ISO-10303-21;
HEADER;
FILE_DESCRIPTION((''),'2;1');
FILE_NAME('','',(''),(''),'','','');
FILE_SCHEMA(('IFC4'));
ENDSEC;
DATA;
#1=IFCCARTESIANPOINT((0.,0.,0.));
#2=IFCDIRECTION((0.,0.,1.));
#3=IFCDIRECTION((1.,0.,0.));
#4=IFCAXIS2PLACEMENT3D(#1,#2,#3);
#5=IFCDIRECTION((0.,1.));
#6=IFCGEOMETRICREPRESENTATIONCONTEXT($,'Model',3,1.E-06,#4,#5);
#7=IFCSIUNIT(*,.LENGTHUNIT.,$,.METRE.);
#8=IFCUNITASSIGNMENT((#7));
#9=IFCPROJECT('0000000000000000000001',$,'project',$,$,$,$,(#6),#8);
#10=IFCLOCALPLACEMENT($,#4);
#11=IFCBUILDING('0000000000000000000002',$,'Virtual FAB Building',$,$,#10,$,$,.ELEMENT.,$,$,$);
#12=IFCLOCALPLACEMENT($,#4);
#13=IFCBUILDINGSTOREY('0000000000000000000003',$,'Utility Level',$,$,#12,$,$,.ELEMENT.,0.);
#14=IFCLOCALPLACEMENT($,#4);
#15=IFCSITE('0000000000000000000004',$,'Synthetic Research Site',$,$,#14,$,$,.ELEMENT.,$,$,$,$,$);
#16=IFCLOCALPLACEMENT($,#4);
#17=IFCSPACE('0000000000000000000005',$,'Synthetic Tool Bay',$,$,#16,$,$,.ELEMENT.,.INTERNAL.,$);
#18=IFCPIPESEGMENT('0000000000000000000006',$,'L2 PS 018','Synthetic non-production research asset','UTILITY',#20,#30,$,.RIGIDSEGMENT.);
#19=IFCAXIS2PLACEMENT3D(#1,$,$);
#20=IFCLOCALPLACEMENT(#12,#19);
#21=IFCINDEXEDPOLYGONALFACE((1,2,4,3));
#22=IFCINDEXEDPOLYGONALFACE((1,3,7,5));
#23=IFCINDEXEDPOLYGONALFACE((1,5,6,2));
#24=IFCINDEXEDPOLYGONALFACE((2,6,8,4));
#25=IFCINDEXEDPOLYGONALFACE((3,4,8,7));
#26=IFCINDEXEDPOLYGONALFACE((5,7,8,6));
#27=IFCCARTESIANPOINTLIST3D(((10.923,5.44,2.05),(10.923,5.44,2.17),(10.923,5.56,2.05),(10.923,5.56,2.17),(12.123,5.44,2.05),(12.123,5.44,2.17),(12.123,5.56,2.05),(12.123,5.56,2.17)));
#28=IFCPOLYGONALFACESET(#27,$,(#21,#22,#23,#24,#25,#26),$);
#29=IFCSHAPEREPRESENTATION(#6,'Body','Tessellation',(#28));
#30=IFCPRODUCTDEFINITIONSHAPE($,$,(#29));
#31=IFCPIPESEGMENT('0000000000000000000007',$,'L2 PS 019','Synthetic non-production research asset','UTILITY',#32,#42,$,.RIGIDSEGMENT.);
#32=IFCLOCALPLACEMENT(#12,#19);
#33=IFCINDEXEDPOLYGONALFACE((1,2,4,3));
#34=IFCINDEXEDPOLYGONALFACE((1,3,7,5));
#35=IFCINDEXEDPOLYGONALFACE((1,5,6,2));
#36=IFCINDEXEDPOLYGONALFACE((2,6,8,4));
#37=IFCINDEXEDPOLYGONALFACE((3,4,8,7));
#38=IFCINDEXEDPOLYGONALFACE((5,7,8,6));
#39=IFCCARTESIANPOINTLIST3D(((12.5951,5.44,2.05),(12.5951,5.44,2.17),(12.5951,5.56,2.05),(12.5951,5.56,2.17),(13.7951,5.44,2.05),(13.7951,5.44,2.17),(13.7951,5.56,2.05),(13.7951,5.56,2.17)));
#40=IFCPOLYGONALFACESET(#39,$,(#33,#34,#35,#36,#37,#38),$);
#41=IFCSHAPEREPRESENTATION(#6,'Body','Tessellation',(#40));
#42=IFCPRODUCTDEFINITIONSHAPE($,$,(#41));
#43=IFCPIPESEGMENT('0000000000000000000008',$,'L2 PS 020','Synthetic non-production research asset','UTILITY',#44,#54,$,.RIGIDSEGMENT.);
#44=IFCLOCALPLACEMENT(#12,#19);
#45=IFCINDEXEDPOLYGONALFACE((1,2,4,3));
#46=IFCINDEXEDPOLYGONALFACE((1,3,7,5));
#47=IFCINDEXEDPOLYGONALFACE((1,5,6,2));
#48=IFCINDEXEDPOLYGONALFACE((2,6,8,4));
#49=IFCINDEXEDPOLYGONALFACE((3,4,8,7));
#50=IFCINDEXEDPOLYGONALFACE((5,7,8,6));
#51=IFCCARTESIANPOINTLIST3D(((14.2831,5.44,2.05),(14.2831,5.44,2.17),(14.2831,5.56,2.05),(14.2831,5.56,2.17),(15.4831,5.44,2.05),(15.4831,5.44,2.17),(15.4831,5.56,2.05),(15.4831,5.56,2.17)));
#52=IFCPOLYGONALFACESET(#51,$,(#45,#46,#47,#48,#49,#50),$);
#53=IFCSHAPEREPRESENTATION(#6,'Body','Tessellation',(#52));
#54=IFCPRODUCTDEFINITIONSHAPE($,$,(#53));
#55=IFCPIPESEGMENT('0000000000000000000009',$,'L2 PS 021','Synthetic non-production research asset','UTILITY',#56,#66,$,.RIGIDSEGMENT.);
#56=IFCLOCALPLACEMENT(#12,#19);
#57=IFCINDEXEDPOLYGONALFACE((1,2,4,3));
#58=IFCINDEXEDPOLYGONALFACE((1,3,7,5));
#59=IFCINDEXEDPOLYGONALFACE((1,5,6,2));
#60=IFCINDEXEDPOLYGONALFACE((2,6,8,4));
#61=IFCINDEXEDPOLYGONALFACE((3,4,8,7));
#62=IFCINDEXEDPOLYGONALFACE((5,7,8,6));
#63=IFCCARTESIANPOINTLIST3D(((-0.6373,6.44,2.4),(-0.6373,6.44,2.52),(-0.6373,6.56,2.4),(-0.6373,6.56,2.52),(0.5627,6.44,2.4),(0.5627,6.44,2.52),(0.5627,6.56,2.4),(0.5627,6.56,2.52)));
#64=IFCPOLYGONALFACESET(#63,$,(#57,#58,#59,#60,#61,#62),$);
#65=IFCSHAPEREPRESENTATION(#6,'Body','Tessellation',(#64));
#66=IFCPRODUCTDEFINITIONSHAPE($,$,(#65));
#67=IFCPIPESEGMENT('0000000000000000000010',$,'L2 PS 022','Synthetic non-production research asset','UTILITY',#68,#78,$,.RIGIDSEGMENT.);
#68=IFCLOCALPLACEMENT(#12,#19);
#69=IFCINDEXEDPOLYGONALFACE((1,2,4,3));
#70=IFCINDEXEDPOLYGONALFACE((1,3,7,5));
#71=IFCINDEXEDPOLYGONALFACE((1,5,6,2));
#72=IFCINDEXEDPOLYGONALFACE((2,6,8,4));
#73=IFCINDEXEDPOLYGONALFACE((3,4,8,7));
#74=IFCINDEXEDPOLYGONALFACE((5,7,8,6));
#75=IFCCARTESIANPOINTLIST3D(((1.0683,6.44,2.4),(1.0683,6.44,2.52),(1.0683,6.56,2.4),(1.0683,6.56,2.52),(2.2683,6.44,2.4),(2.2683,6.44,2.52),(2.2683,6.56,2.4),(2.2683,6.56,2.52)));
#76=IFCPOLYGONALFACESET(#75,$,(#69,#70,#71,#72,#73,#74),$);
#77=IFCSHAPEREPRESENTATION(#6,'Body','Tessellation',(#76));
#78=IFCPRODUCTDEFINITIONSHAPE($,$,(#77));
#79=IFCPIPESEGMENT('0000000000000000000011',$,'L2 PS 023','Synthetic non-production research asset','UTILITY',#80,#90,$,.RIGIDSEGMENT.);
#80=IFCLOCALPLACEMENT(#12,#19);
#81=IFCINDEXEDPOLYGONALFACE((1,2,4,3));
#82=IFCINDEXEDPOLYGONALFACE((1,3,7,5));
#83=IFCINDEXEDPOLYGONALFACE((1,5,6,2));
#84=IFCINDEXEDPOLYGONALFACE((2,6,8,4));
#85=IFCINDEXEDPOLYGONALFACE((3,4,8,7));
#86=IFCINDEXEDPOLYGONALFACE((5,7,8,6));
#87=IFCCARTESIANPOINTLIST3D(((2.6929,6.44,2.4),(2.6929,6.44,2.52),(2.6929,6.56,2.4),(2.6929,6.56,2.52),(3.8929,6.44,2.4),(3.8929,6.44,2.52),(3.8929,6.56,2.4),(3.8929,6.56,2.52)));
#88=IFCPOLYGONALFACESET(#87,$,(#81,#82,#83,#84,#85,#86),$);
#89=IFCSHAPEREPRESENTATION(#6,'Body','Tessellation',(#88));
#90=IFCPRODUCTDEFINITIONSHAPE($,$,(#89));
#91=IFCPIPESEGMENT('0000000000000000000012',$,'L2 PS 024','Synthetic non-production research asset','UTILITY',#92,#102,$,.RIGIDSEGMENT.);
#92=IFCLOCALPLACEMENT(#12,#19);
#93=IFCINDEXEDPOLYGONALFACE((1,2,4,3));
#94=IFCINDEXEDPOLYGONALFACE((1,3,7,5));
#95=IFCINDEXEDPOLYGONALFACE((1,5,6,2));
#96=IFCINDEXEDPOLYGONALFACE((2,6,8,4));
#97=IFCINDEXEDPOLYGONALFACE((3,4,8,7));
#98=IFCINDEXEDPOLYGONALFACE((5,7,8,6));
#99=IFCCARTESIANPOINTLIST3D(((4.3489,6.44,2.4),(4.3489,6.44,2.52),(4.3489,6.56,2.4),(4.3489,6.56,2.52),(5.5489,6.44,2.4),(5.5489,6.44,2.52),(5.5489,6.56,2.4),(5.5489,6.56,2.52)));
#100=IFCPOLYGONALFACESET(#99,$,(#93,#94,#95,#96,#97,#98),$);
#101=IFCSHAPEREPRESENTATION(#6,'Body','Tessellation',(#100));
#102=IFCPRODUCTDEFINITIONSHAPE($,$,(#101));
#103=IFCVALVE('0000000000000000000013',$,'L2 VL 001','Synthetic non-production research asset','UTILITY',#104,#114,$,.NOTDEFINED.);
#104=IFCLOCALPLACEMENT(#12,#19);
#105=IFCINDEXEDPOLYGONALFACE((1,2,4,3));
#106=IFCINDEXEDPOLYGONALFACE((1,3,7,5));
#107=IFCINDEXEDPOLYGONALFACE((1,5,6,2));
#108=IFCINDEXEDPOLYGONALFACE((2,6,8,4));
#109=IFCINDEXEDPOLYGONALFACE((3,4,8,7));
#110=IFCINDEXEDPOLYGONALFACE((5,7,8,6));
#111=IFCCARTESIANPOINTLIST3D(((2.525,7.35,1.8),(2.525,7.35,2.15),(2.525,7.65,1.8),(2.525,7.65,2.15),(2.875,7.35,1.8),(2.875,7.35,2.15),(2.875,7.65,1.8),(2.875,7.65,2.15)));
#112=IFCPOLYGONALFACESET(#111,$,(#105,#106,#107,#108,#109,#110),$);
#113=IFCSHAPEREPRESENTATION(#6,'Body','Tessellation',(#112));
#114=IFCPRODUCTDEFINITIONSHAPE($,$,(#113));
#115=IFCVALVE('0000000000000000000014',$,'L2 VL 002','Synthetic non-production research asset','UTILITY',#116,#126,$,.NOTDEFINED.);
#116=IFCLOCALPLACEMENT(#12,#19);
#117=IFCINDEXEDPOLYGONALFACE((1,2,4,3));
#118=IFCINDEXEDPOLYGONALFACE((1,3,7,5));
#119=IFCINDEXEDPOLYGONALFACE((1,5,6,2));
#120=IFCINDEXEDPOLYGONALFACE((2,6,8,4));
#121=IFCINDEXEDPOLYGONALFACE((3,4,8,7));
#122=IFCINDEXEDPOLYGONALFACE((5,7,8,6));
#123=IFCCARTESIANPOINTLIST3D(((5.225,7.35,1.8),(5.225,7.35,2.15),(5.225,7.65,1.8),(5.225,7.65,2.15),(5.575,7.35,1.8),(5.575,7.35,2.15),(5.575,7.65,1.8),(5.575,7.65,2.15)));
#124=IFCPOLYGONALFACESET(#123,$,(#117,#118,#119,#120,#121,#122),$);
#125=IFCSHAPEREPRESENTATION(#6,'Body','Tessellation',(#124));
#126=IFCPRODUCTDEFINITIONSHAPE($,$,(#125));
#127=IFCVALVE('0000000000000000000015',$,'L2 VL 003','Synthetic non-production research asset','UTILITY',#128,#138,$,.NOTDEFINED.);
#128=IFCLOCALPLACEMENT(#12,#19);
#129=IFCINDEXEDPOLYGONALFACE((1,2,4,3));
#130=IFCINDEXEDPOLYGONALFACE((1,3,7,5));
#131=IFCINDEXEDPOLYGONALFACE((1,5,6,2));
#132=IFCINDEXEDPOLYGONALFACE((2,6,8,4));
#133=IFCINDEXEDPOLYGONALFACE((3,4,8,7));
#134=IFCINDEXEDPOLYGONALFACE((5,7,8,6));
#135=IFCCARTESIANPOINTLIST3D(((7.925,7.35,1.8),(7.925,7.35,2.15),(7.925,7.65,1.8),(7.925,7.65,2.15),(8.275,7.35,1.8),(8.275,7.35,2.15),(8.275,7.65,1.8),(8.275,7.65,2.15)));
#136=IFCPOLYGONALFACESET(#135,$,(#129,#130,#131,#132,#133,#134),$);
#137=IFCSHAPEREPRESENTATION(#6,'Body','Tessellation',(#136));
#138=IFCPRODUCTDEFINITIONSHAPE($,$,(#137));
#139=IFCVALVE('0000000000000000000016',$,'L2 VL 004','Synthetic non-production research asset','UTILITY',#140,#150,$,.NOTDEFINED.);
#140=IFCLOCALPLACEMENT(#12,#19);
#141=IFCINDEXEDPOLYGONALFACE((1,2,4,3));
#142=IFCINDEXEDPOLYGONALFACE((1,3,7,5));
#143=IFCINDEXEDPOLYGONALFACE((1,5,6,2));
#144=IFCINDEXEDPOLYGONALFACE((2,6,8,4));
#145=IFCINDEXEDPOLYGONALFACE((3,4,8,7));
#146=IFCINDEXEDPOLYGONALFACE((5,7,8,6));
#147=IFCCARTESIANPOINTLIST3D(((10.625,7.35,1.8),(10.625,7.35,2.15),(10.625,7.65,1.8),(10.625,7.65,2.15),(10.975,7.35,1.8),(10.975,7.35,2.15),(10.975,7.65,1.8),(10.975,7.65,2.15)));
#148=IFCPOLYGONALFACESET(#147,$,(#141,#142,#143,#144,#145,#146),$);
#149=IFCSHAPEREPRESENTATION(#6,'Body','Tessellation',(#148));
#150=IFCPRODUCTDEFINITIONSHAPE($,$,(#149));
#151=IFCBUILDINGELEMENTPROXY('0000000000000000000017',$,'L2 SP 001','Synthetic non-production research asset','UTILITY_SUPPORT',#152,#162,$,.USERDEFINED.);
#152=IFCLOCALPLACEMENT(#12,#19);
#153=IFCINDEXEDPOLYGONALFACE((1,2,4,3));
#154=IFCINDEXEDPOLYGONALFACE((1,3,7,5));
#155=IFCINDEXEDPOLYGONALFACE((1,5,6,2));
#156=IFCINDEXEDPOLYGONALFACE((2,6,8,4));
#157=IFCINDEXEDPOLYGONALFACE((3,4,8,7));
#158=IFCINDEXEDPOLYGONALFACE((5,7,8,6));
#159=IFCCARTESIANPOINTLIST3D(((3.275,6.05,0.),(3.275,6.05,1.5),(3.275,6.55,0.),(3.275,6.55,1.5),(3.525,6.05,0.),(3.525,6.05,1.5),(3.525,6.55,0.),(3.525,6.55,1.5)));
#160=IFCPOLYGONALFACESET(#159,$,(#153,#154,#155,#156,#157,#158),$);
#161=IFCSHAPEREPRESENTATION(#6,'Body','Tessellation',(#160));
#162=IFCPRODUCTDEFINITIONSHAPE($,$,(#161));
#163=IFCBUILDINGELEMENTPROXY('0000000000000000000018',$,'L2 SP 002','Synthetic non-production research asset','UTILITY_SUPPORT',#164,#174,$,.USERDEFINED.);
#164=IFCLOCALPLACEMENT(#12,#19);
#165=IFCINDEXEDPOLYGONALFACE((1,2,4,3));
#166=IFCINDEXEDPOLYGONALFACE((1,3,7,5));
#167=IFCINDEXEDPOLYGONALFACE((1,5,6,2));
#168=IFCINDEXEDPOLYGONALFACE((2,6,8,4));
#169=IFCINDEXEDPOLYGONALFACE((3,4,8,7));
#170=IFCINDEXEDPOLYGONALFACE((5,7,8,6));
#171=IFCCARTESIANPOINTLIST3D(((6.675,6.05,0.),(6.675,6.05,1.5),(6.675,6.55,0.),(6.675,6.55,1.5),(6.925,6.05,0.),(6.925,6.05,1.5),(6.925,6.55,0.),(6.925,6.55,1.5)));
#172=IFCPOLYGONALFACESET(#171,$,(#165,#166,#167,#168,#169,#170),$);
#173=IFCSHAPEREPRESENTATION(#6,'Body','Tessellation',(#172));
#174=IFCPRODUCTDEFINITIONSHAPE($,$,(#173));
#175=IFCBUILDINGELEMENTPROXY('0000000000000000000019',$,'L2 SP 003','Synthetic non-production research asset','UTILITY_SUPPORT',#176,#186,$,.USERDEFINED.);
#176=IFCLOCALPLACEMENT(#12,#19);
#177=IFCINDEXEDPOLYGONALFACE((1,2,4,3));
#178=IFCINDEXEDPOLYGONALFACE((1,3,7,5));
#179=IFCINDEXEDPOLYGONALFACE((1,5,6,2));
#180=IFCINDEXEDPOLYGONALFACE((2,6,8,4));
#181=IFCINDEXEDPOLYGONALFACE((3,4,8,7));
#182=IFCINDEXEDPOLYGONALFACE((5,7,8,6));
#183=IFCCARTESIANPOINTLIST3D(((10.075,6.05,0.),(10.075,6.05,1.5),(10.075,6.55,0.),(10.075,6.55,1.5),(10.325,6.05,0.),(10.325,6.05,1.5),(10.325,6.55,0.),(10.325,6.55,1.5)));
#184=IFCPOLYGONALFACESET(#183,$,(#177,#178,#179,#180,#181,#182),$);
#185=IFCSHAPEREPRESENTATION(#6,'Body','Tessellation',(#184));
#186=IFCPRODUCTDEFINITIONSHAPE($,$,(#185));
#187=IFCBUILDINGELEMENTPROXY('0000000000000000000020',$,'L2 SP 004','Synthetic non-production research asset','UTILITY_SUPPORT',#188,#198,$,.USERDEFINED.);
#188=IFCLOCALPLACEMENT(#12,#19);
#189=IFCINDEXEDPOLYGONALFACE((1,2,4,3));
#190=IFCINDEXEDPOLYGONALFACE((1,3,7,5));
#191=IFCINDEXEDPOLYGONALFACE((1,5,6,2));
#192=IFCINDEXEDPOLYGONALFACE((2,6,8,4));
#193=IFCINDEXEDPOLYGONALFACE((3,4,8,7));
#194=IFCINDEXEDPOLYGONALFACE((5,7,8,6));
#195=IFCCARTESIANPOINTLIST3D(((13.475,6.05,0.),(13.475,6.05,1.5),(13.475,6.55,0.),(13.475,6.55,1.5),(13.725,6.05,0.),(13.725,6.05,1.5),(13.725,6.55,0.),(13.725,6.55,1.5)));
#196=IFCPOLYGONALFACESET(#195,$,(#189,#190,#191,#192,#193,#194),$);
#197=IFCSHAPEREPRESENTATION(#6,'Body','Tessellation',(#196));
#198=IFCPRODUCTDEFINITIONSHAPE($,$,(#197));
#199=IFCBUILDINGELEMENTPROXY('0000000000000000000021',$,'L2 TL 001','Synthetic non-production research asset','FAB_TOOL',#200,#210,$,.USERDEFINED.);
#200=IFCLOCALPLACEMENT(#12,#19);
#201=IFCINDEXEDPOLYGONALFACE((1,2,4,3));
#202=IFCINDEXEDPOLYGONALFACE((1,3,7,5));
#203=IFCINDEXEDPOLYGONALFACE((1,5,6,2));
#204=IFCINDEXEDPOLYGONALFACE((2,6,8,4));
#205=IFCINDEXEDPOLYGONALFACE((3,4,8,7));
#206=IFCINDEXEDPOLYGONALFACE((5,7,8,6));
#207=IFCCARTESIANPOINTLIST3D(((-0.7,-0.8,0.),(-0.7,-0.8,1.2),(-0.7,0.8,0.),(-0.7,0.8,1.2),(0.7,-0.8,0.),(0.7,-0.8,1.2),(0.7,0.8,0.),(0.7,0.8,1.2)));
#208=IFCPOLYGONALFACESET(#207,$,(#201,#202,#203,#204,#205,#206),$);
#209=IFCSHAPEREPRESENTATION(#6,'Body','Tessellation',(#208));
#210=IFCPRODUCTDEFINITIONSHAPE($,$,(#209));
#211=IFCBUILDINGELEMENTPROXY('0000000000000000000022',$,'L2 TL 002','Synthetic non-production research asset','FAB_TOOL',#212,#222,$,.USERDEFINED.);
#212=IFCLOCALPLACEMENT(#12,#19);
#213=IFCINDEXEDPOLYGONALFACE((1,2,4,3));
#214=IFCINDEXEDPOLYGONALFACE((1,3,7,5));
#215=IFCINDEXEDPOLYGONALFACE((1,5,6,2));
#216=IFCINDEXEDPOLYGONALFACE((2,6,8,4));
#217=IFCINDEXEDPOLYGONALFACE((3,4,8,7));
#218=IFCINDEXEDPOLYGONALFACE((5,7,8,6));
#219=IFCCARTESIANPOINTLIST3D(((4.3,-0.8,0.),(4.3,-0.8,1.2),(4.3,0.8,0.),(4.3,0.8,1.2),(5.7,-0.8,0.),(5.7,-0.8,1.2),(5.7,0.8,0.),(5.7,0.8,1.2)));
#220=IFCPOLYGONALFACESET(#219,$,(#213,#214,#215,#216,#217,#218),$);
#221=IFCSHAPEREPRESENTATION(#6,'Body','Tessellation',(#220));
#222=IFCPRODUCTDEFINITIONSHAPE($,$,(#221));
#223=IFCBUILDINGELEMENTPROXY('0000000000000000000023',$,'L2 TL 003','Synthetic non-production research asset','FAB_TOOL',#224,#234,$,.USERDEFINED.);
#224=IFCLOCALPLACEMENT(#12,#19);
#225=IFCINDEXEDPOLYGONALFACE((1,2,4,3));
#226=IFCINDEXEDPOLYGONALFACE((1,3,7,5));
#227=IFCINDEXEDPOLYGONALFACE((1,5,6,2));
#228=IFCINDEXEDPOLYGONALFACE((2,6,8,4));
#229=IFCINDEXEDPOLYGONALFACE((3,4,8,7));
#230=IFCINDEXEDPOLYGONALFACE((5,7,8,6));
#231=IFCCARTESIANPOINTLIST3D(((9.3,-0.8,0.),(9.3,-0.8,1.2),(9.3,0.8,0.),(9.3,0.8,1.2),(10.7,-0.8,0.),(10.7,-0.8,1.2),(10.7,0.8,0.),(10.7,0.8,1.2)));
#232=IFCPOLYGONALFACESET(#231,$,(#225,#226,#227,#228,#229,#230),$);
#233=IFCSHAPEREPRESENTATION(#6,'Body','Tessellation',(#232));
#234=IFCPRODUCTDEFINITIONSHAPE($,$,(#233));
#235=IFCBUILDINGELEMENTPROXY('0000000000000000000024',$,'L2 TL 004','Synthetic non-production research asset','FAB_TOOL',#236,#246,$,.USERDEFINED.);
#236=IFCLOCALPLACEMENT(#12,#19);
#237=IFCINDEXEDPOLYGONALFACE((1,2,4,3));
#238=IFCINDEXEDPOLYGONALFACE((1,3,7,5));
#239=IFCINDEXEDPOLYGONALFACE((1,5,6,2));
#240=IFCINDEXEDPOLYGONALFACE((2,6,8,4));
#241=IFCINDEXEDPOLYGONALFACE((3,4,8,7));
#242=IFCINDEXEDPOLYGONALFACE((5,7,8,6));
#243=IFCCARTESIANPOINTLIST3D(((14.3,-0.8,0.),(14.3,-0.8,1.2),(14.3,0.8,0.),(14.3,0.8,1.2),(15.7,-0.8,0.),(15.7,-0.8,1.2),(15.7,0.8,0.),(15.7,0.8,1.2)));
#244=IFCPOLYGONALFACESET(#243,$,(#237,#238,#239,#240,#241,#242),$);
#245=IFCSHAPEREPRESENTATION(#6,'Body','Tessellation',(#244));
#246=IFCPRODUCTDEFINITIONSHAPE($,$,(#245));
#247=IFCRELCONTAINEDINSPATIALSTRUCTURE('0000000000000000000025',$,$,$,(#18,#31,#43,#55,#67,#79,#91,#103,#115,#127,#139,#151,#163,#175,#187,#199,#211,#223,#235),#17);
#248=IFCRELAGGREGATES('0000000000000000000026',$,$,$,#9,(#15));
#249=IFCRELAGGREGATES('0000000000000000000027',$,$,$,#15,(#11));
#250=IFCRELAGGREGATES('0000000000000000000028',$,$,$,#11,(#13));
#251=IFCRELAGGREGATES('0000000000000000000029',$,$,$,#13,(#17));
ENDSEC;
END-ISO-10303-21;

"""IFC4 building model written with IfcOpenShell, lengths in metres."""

from ifc_helpers import new_model, si_unit, direction, frame, origin_with_axes, origin_2d_with_axis, place, context, project, spatial, rectangle, extrude, element, save


model = new_model("IFC4")

# Units and contexts
model_context = context("Model", 3, precision=1e-06, world=origin_with_axes(), true_north=direction((0.0, 1.0)))
ifc_project = project(units=[si_unit("LENGTHUNIT", "METRE")], contexts=[model_context])

# Site, building, storey, space
site_placement = place(None, origin_with_axes())
site = spatial("IfcSite", under=ifc_project, at=site_placement, Name="Synthetic Research Site", CompositionType="ELEMENT")
building_placement = place(None, origin_with_axes())
building = spatial("IfcBuilding", under=site, at=building_placement, Name="Virtual FAB Building", CompositionType="ELEMENT")
storey_placement = place(None, origin_with_axes())
storey = spatial("IfcBuildingStorey", under=building, at=storey_placement, Name="Utility Level", CompositionType="ELEMENT", Elevation=0.0)
space_placement = place(None, origin_with_axes())
space = spatial("IfcSpace", under=storey, at=space_placement, Name="Synthetic Tool Bay", CompositionType="ELEMENT", PredefinedType="INTERNAL")

# Pipe segments
for number, where, z_axis, x_axis, name in (
    (1, (11.523, 5.5, 2.05), (0.0, 0.0, 1.0), (1.0, 0.0, 0.0), "L2 PS 018"),
    (2, (13.1951, 5.5, 2.05), (0.0, 0.0, 1.0), (1.0, 0.0, 0.0), "L2 PS 019"),
    (3, (14.8831, 5.5, 2.05), (0.0, 0.0, 1.0), (1.0, 0.0, 0.0), "L2 PS 020"),
    (4, (-0.0373, 6.5, 2.4), (0.0, 0.0, 1.0), (1.0, 0.0, 0.0), "L2 PS 021"),
    (5, (1.6683, 6.5, 2.4), (0.0, 0.0, 1.0), (1.0, 0.0, 0.0), "L2 PS 022"),
    (6, (3.2929, 6.5, 2.4), (0.0, 0.0, 1.0), (1.0, 0.0, 0.0), "L2 PS 023"),
    (7, (4.9489, 6.5, 2.4), (0.0, 0.0, 1.0), (1.0, 0.0, 0.0), "L2 PS 024"),
):
    element("IfcPipeSegment", number, at=place(None, frame(where, z_axis=z_axis, x_axis=x_axis)), inside=space, Name=name, Description="Synthetic non-production research asset", ObjectType="UTILITY", PredefinedType="RIGIDSEGMENT", context=model_context, shape_type="SweptSolid", body=[
        extrude(rectangle(XDim=1.2, YDim=0.12, at=origin_2d_with_axis()), origin_with_axes(), (0.0, 0.0, 1.0), 0.12),
    ])

# Valves
for number, where, z_axis, x_axis, name in (
    (8, (2.7, 7.5, 1.8), (0.0, 0.0, 1.0), (1.0, 0.0, 0.0), "L2 VL 001"),
    (9, (5.4, 7.5, 1.8), (0.0, 0.0, 1.0), (1.0, 0.0, 0.0), "L2 VL 002"),
    (10, (8.1, 7.5, 1.8), (0.0, 0.0, 1.0), (1.0, 0.0, 0.0), "L2 VL 003"),
    (11, (10.8, 7.5, 1.8), (0.0, 0.0, 1.0), (1.0, 0.0, 0.0), "L2 VL 004"),
):
    element("IfcValve", number, at=place(None, frame(where, z_axis=z_axis, x_axis=x_axis)), inside=space, Name=name, Description="Synthetic non-production research asset", ObjectType="UTILITY", PredefinedType="NOTDEFINED", context=model_context, shape_type="SweptSolid", body=[
        extrude(rectangle(XDim=0.35, YDim=0.3, at=origin_2d_with_axis()), origin_with_axes(), (0.0, 0.0, 1.0), 0.35),
    ])

# Building element proxies
for number, where, z_axis, x_axis, name in (
    (12, (3.4, 6.3, 0.0), (0.0, 0.0, 1.0), (1.0, 0.0, 0.0), "L2 SP 001"),
    (13, (6.8, 6.3, 0.0), (0.0, 0.0, 1.0), (1.0, 0.0, 0.0), "L2 SP 002"),
    (14, (10.2, 6.3, 0.0), (0.0, 0.0, 1.0), (1.0, 0.0, 0.0), "L2 SP 003"),
    (15, (13.6, 6.3, 0.0), (0.0, 0.0, 1.0), (1.0, 0.0, 0.0), "L2 SP 004"),
):
    element("IfcBuildingElementProxy", number, at=place(None, frame(where, z_axis=z_axis, x_axis=x_axis)), inside=space, Name=name, Description="Synthetic non-production research asset", ObjectType="UTILITY_SUPPORT", PredefinedType="USERDEFINED", context=model_context, shape_type="SweptSolid", body=[
        extrude(rectangle(XDim=0.25, YDim=0.5, at=origin_2d_with_axis()), origin_with_axes(), (0.0, 0.0, 1.0), 1.5),
    ])
for number, where, z_axis, x_axis, name in (
    (16, (0.0, 0.0, 0.0), (0.0, 0.0, 1.0), (1.0, 0.0, 0.0), "L2 TL 001"),
    (17, (5.0, 0.0, 0.0), (0.0, 0.0, 1.0), (1.0, 0.0, 0.0), "L2 TL 002"),
    (18, (10.0, 0.0, 0.0), (0.0, 0.0, 1.0), (1.0, 0.0, 0.0), "L2 TL 003"),
    (19, (15.0, 0.0, 0.0), (0.0, 0.0, 1.0), (1.0, 0.0, 0.0), "L2 TL 004"),
):
    element("IfcBuildingElementProxy", number, at=place(None, frame(where, z_axis=z_axis, x_axis=x_axis)), inside=space, Name=name, Description="Synthetic non-production research asset", ObjectType="FAB_TOOL", PredefinedType="USERDEFINED", context=model_context, shape_type="SweptSolid", body=[
        extrude(rectangle(XDim=1.4, YDim=1.6, at=origin_2d_with_axis()), origin_with_axes(), (0.0, 0.0, 1.0), 1.2),
    ])

save(model, "model.ifc")
